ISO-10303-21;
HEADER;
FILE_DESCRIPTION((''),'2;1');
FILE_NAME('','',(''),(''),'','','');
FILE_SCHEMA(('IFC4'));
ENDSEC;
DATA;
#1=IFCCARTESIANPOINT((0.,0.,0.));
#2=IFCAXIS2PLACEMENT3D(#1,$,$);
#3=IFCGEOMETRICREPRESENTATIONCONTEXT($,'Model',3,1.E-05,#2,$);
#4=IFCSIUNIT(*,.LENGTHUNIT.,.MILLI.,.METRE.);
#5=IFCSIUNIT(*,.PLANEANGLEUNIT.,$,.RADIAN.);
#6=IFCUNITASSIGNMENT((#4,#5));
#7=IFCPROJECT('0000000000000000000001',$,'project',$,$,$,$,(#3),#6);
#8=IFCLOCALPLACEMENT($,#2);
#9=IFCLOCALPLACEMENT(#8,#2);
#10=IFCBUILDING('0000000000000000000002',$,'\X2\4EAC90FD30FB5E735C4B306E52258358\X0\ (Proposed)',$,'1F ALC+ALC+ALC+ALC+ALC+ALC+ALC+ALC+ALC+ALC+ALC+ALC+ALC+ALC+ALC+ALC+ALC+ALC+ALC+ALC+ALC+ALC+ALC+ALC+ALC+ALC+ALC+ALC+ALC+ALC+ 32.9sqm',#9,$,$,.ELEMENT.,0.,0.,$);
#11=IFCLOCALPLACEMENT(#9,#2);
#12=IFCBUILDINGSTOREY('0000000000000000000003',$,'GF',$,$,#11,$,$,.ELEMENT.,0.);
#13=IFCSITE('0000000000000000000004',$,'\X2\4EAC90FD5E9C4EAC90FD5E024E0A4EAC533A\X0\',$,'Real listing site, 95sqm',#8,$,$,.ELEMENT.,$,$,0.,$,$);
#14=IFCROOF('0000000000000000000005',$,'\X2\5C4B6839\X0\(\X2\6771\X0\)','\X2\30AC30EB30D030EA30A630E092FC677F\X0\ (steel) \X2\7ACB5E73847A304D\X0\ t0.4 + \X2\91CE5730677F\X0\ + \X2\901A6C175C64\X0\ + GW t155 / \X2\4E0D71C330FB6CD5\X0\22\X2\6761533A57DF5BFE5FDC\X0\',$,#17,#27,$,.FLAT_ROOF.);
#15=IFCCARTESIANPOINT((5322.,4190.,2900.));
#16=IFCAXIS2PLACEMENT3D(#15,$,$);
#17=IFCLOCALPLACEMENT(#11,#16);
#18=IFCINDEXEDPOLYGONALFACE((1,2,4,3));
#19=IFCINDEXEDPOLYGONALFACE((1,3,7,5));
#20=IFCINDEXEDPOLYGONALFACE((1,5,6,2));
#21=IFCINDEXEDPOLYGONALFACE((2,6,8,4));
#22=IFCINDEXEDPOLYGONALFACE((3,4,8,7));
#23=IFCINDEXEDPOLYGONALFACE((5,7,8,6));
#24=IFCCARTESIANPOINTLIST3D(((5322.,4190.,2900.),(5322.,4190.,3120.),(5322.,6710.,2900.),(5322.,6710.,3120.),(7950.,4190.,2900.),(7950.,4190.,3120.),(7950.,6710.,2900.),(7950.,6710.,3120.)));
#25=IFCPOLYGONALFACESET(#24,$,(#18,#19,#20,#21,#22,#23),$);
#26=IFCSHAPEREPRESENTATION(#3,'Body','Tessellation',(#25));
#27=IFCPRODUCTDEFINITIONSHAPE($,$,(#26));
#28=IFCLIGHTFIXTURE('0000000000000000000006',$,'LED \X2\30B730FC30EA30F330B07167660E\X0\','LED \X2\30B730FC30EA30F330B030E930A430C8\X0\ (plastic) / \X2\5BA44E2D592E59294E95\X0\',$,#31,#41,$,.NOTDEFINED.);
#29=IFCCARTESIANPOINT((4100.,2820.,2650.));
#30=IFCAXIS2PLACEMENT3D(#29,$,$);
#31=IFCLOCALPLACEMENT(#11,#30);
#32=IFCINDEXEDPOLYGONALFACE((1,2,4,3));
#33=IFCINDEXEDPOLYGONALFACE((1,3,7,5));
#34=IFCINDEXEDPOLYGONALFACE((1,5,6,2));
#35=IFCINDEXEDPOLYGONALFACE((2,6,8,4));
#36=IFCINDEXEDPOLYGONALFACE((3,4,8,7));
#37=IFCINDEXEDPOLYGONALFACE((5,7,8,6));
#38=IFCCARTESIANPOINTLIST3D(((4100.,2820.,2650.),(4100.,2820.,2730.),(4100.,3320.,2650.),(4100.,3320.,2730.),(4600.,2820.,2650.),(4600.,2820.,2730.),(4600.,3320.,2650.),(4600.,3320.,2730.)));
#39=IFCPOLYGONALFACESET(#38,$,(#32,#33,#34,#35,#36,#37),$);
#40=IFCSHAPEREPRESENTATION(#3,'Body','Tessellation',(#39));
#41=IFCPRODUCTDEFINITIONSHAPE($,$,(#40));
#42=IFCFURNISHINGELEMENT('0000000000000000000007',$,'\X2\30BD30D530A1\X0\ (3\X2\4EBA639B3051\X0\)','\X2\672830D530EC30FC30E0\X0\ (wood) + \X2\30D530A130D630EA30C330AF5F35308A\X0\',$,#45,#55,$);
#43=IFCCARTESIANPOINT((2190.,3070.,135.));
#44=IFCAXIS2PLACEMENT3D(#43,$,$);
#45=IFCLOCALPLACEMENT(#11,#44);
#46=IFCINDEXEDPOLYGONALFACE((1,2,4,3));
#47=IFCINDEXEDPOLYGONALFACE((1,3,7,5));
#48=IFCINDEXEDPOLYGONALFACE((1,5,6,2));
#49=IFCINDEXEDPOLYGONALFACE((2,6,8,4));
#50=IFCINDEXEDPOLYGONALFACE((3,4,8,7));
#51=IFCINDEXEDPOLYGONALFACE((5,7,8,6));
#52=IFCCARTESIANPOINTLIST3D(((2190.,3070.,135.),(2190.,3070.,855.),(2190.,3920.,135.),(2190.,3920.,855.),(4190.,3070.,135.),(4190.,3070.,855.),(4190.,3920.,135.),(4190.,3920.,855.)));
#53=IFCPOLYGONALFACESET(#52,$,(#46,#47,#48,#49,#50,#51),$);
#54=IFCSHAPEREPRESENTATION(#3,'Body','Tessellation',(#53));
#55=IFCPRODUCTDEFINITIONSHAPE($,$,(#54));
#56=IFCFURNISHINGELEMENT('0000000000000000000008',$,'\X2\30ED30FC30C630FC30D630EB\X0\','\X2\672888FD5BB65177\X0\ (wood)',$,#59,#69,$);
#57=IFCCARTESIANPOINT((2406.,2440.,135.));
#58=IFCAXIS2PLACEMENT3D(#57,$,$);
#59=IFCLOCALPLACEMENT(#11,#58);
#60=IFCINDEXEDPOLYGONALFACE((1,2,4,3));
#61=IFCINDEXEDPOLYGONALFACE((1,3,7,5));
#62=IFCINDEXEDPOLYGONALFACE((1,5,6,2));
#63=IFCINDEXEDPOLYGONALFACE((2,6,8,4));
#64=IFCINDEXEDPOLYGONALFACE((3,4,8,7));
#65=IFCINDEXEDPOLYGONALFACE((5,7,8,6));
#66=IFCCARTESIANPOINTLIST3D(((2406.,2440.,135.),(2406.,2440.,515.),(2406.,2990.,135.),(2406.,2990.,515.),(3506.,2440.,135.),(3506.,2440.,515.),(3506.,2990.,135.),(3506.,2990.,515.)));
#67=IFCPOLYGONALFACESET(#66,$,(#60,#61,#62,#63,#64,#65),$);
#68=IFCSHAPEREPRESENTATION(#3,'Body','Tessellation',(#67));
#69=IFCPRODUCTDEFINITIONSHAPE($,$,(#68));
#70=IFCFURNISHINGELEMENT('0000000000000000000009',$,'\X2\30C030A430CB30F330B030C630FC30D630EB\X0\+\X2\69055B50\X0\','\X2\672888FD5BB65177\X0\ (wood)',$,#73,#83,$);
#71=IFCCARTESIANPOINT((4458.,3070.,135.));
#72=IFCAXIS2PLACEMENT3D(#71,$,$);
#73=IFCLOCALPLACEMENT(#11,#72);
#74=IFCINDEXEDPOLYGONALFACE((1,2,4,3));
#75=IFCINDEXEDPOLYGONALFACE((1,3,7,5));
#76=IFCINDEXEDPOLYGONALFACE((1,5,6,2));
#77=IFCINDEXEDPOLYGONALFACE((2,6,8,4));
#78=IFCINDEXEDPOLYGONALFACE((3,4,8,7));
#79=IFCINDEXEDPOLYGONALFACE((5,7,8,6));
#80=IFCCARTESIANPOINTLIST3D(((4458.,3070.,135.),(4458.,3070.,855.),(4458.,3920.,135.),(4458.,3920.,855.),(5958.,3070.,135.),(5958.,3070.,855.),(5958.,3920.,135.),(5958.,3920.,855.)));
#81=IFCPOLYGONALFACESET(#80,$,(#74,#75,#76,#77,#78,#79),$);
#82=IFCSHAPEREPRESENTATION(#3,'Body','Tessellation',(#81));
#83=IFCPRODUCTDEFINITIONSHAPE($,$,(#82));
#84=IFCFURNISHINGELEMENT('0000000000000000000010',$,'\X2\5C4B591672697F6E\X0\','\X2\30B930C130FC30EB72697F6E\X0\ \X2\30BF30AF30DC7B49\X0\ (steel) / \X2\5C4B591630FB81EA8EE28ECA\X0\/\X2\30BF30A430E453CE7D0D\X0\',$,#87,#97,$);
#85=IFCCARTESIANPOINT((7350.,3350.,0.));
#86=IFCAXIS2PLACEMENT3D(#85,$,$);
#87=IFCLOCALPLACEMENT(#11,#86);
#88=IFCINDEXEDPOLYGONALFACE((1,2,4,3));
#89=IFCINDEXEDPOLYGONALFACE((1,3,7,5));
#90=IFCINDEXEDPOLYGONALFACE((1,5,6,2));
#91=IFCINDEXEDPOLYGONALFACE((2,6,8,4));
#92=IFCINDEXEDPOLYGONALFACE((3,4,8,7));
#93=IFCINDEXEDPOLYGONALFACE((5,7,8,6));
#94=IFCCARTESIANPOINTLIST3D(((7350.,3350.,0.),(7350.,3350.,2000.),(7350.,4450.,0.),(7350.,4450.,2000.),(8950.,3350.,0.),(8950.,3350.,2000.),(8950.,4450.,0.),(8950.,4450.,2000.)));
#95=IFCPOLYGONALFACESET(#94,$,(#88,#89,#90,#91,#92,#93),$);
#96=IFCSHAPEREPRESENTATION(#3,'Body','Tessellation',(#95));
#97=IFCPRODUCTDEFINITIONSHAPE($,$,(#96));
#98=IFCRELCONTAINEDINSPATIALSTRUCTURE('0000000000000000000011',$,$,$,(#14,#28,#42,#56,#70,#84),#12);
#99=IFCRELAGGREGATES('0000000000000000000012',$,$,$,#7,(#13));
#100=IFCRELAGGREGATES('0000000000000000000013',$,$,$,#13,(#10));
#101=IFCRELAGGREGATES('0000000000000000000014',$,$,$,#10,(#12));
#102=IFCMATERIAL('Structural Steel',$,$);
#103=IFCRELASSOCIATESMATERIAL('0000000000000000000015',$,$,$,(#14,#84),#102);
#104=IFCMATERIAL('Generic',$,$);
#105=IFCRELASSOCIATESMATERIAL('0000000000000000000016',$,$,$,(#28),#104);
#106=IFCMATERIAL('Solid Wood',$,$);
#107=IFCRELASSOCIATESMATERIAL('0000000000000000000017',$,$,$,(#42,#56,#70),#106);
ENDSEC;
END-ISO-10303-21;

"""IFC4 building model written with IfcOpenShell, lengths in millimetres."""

from ifc_helpers import new_model, si_unit, frame, frame_2d, origin, place, context, project, spatial, rectangle, extrude, material, element, save


model = new_model("IFC4")

# Units and contexts
model_context = context("Model", 3, precision=1e-05, world=origin())
ifc_project = project(units=[si_unit("LENGTHUNIT", "METRE", prefix="MILLI"), si_unit("PLANEANGLEUNIT", "RADIAN")], contexts=[model_context])

# Site, building, storey
site_placement = place(None, origin())
site = spatial("IfcSite", under=ifc_project, at=site_placement, Name="京都府京都市上京区", ObjectType="Real listing site, 95sqm", CompositionType="ELEMENT", RefElevation=0.0)
building_placement = place(site_placement, origin())
building = spatial("IfcBuilding", under=site, at=building_placement, Name="京都・平屋の別荘 (Proposed)", ObjectType="1F ALC+ALC+ALC+ALC+ALC+ALC+ALC+ALC+ALC+ALC+ALC+ALC+ALC+ALC+ALC+ALC+ALC+ALC+ALC+ALC+ALC+ALC+ALC+ALC+ALC+ALC+ALC+ALC+ALC+ALC+ 32.9sqm", CompositionType="ELEMENT", ElevationOfRefHeight=0.0, ElevationOfTerrain=0.0)
storey_placement = place(building_placement, origin())
storey = spatial("IfcBuildingStorey", under=building, at=storey_placement, Name="GF", CompositionType="ELEMENT", Elevation=0.0)

# Shared definitions
ifc_material_1 = material(Name="Solid Wood")

# Roof
ifc_material_2 = material(Name="Structural Steel")
roof_1_placement = place(storey_placement, frame((5322.0, 4190.0, 2900.0)))
element("IfcRoof", 1, at=roof_1_placement, inside=storey, material=ifc_material_2, Name="屋根(東)", Description="ガルバリウム鋼板 (steel) 立平葺き t0.4 + 野地板 + 通気層 + GW t155 / 不燃・法22条区域対応", PredefinedType="FLAT_ROOF", context=model_context, shape_type="SweptSolid", body=[
    extrude(rectangle(XDim=2628.0, YDim=2520.0, at=frame_2d((1314.0, 1260.0))), frame((5322.0, 4190.0, 2900.0)), (0.0, 0.0, 1.0), 220.0),
])

# Light fixture
ifc_material_3 = material(Name="Generic")
light_fixture_placement = place(storey_placement, frame((4100.0, 2820.0, 2650.0)))
element("IfcLightFixture", 2, at=light_fixture_placement, inside=storey, material=ifc_material_3, Name="LED シーリング照明", Description="LED シーリングライト (plastic) / 室中央天井", PredefinedType="NOTDEFINED", context=model_context, shape_type="SweptSolid", body=[
    extrude(rectangle(XDim=500.0, YDim=500.0, at=frame_2d((250.0, 250.0))), frame((4100.0, 2820.0, 2650.0)), (0.0, 0.0, 1.0), 80.0),
])

# Furnishing elements
furnishing_1_placement = place(storey_placement, frame((2190.0, 3070.0, 135.0)))
element("IfcFurnishingElement", 3, at=furnishing_1_placement, inside=storey, material=ifc_material_1, Name="ソファ (3人掛け)", Description="木フレーム (wood) + ファブリック張り", context=model_context, shape_type="SweptSolid", body=[
    extrude(rectangle(XDim=2000.0, YDim=850.0, at=frame_2d((1000.0, 425.0))), frame((2190.0, 3070.0, 135.0)), (0.0, 0.0, 1.0), 720.0),
])
furnishing_2_placement = place(storey_placement, frame((2406.0, 2440.0, 135.0)))
element("IfcFurnishingElement", 4, at=furnishing_2_placement, inside=storey, material=ifc_material_1, Name="ローテーブル", Description="木製家具 (wood)", context=model_context, shape_type="SweptSolid", body=[
    extrude(rectangle(XDim=1100.0, YDim=550.0, at=frame_2d((550.0, 275.0))), frame((2406.0, 2440.0, 135.0)), (0.0, 0.0, 1.0), 380.0),
])
furnishing_3_placement = place(storey_placement, frame((4458.0, 3070.0, 135.0)))
element("IfcFurnishingElement", 5, at=furnishing_3_placement, inside=storey, material=ifc_material_1, Name="ダイニングテーブル+椅子", Description="木製家具 (wood)", context=model_context, shape_type="SweptSolid", body=[
    extrude(rectangle(XDim=1500.0, YDim=850.0, at=frame_2d((750.0, 425.0))), frame((4458.0, 3070.0, 135.0)), (0.0, 0.0, 1.0), 720.0),
])
furnishing_4_placement = place(storey_placement, frame((7350.0, 3350.0, 0.0)))
element("IfcFurnishingElement", 6, at=furnishing_4_placement, inside=storey, material=ifc_material_2, Name="屋外物置", Description="スチール物置 タクボ等 (steel) / 屋外・自転車/タイヤ収納", context=model_context, shape_type="SweptSolid", body=[
    extrude(rectangle(XDim=1600.0, YDim=1100.0, at=frame_2d((800.0, 550.0))), frame((7350.0, 3350.0, 0.0)), (0.0, 0.0, 1.0), 2000.0),
])

save(model, "model.ifc")
